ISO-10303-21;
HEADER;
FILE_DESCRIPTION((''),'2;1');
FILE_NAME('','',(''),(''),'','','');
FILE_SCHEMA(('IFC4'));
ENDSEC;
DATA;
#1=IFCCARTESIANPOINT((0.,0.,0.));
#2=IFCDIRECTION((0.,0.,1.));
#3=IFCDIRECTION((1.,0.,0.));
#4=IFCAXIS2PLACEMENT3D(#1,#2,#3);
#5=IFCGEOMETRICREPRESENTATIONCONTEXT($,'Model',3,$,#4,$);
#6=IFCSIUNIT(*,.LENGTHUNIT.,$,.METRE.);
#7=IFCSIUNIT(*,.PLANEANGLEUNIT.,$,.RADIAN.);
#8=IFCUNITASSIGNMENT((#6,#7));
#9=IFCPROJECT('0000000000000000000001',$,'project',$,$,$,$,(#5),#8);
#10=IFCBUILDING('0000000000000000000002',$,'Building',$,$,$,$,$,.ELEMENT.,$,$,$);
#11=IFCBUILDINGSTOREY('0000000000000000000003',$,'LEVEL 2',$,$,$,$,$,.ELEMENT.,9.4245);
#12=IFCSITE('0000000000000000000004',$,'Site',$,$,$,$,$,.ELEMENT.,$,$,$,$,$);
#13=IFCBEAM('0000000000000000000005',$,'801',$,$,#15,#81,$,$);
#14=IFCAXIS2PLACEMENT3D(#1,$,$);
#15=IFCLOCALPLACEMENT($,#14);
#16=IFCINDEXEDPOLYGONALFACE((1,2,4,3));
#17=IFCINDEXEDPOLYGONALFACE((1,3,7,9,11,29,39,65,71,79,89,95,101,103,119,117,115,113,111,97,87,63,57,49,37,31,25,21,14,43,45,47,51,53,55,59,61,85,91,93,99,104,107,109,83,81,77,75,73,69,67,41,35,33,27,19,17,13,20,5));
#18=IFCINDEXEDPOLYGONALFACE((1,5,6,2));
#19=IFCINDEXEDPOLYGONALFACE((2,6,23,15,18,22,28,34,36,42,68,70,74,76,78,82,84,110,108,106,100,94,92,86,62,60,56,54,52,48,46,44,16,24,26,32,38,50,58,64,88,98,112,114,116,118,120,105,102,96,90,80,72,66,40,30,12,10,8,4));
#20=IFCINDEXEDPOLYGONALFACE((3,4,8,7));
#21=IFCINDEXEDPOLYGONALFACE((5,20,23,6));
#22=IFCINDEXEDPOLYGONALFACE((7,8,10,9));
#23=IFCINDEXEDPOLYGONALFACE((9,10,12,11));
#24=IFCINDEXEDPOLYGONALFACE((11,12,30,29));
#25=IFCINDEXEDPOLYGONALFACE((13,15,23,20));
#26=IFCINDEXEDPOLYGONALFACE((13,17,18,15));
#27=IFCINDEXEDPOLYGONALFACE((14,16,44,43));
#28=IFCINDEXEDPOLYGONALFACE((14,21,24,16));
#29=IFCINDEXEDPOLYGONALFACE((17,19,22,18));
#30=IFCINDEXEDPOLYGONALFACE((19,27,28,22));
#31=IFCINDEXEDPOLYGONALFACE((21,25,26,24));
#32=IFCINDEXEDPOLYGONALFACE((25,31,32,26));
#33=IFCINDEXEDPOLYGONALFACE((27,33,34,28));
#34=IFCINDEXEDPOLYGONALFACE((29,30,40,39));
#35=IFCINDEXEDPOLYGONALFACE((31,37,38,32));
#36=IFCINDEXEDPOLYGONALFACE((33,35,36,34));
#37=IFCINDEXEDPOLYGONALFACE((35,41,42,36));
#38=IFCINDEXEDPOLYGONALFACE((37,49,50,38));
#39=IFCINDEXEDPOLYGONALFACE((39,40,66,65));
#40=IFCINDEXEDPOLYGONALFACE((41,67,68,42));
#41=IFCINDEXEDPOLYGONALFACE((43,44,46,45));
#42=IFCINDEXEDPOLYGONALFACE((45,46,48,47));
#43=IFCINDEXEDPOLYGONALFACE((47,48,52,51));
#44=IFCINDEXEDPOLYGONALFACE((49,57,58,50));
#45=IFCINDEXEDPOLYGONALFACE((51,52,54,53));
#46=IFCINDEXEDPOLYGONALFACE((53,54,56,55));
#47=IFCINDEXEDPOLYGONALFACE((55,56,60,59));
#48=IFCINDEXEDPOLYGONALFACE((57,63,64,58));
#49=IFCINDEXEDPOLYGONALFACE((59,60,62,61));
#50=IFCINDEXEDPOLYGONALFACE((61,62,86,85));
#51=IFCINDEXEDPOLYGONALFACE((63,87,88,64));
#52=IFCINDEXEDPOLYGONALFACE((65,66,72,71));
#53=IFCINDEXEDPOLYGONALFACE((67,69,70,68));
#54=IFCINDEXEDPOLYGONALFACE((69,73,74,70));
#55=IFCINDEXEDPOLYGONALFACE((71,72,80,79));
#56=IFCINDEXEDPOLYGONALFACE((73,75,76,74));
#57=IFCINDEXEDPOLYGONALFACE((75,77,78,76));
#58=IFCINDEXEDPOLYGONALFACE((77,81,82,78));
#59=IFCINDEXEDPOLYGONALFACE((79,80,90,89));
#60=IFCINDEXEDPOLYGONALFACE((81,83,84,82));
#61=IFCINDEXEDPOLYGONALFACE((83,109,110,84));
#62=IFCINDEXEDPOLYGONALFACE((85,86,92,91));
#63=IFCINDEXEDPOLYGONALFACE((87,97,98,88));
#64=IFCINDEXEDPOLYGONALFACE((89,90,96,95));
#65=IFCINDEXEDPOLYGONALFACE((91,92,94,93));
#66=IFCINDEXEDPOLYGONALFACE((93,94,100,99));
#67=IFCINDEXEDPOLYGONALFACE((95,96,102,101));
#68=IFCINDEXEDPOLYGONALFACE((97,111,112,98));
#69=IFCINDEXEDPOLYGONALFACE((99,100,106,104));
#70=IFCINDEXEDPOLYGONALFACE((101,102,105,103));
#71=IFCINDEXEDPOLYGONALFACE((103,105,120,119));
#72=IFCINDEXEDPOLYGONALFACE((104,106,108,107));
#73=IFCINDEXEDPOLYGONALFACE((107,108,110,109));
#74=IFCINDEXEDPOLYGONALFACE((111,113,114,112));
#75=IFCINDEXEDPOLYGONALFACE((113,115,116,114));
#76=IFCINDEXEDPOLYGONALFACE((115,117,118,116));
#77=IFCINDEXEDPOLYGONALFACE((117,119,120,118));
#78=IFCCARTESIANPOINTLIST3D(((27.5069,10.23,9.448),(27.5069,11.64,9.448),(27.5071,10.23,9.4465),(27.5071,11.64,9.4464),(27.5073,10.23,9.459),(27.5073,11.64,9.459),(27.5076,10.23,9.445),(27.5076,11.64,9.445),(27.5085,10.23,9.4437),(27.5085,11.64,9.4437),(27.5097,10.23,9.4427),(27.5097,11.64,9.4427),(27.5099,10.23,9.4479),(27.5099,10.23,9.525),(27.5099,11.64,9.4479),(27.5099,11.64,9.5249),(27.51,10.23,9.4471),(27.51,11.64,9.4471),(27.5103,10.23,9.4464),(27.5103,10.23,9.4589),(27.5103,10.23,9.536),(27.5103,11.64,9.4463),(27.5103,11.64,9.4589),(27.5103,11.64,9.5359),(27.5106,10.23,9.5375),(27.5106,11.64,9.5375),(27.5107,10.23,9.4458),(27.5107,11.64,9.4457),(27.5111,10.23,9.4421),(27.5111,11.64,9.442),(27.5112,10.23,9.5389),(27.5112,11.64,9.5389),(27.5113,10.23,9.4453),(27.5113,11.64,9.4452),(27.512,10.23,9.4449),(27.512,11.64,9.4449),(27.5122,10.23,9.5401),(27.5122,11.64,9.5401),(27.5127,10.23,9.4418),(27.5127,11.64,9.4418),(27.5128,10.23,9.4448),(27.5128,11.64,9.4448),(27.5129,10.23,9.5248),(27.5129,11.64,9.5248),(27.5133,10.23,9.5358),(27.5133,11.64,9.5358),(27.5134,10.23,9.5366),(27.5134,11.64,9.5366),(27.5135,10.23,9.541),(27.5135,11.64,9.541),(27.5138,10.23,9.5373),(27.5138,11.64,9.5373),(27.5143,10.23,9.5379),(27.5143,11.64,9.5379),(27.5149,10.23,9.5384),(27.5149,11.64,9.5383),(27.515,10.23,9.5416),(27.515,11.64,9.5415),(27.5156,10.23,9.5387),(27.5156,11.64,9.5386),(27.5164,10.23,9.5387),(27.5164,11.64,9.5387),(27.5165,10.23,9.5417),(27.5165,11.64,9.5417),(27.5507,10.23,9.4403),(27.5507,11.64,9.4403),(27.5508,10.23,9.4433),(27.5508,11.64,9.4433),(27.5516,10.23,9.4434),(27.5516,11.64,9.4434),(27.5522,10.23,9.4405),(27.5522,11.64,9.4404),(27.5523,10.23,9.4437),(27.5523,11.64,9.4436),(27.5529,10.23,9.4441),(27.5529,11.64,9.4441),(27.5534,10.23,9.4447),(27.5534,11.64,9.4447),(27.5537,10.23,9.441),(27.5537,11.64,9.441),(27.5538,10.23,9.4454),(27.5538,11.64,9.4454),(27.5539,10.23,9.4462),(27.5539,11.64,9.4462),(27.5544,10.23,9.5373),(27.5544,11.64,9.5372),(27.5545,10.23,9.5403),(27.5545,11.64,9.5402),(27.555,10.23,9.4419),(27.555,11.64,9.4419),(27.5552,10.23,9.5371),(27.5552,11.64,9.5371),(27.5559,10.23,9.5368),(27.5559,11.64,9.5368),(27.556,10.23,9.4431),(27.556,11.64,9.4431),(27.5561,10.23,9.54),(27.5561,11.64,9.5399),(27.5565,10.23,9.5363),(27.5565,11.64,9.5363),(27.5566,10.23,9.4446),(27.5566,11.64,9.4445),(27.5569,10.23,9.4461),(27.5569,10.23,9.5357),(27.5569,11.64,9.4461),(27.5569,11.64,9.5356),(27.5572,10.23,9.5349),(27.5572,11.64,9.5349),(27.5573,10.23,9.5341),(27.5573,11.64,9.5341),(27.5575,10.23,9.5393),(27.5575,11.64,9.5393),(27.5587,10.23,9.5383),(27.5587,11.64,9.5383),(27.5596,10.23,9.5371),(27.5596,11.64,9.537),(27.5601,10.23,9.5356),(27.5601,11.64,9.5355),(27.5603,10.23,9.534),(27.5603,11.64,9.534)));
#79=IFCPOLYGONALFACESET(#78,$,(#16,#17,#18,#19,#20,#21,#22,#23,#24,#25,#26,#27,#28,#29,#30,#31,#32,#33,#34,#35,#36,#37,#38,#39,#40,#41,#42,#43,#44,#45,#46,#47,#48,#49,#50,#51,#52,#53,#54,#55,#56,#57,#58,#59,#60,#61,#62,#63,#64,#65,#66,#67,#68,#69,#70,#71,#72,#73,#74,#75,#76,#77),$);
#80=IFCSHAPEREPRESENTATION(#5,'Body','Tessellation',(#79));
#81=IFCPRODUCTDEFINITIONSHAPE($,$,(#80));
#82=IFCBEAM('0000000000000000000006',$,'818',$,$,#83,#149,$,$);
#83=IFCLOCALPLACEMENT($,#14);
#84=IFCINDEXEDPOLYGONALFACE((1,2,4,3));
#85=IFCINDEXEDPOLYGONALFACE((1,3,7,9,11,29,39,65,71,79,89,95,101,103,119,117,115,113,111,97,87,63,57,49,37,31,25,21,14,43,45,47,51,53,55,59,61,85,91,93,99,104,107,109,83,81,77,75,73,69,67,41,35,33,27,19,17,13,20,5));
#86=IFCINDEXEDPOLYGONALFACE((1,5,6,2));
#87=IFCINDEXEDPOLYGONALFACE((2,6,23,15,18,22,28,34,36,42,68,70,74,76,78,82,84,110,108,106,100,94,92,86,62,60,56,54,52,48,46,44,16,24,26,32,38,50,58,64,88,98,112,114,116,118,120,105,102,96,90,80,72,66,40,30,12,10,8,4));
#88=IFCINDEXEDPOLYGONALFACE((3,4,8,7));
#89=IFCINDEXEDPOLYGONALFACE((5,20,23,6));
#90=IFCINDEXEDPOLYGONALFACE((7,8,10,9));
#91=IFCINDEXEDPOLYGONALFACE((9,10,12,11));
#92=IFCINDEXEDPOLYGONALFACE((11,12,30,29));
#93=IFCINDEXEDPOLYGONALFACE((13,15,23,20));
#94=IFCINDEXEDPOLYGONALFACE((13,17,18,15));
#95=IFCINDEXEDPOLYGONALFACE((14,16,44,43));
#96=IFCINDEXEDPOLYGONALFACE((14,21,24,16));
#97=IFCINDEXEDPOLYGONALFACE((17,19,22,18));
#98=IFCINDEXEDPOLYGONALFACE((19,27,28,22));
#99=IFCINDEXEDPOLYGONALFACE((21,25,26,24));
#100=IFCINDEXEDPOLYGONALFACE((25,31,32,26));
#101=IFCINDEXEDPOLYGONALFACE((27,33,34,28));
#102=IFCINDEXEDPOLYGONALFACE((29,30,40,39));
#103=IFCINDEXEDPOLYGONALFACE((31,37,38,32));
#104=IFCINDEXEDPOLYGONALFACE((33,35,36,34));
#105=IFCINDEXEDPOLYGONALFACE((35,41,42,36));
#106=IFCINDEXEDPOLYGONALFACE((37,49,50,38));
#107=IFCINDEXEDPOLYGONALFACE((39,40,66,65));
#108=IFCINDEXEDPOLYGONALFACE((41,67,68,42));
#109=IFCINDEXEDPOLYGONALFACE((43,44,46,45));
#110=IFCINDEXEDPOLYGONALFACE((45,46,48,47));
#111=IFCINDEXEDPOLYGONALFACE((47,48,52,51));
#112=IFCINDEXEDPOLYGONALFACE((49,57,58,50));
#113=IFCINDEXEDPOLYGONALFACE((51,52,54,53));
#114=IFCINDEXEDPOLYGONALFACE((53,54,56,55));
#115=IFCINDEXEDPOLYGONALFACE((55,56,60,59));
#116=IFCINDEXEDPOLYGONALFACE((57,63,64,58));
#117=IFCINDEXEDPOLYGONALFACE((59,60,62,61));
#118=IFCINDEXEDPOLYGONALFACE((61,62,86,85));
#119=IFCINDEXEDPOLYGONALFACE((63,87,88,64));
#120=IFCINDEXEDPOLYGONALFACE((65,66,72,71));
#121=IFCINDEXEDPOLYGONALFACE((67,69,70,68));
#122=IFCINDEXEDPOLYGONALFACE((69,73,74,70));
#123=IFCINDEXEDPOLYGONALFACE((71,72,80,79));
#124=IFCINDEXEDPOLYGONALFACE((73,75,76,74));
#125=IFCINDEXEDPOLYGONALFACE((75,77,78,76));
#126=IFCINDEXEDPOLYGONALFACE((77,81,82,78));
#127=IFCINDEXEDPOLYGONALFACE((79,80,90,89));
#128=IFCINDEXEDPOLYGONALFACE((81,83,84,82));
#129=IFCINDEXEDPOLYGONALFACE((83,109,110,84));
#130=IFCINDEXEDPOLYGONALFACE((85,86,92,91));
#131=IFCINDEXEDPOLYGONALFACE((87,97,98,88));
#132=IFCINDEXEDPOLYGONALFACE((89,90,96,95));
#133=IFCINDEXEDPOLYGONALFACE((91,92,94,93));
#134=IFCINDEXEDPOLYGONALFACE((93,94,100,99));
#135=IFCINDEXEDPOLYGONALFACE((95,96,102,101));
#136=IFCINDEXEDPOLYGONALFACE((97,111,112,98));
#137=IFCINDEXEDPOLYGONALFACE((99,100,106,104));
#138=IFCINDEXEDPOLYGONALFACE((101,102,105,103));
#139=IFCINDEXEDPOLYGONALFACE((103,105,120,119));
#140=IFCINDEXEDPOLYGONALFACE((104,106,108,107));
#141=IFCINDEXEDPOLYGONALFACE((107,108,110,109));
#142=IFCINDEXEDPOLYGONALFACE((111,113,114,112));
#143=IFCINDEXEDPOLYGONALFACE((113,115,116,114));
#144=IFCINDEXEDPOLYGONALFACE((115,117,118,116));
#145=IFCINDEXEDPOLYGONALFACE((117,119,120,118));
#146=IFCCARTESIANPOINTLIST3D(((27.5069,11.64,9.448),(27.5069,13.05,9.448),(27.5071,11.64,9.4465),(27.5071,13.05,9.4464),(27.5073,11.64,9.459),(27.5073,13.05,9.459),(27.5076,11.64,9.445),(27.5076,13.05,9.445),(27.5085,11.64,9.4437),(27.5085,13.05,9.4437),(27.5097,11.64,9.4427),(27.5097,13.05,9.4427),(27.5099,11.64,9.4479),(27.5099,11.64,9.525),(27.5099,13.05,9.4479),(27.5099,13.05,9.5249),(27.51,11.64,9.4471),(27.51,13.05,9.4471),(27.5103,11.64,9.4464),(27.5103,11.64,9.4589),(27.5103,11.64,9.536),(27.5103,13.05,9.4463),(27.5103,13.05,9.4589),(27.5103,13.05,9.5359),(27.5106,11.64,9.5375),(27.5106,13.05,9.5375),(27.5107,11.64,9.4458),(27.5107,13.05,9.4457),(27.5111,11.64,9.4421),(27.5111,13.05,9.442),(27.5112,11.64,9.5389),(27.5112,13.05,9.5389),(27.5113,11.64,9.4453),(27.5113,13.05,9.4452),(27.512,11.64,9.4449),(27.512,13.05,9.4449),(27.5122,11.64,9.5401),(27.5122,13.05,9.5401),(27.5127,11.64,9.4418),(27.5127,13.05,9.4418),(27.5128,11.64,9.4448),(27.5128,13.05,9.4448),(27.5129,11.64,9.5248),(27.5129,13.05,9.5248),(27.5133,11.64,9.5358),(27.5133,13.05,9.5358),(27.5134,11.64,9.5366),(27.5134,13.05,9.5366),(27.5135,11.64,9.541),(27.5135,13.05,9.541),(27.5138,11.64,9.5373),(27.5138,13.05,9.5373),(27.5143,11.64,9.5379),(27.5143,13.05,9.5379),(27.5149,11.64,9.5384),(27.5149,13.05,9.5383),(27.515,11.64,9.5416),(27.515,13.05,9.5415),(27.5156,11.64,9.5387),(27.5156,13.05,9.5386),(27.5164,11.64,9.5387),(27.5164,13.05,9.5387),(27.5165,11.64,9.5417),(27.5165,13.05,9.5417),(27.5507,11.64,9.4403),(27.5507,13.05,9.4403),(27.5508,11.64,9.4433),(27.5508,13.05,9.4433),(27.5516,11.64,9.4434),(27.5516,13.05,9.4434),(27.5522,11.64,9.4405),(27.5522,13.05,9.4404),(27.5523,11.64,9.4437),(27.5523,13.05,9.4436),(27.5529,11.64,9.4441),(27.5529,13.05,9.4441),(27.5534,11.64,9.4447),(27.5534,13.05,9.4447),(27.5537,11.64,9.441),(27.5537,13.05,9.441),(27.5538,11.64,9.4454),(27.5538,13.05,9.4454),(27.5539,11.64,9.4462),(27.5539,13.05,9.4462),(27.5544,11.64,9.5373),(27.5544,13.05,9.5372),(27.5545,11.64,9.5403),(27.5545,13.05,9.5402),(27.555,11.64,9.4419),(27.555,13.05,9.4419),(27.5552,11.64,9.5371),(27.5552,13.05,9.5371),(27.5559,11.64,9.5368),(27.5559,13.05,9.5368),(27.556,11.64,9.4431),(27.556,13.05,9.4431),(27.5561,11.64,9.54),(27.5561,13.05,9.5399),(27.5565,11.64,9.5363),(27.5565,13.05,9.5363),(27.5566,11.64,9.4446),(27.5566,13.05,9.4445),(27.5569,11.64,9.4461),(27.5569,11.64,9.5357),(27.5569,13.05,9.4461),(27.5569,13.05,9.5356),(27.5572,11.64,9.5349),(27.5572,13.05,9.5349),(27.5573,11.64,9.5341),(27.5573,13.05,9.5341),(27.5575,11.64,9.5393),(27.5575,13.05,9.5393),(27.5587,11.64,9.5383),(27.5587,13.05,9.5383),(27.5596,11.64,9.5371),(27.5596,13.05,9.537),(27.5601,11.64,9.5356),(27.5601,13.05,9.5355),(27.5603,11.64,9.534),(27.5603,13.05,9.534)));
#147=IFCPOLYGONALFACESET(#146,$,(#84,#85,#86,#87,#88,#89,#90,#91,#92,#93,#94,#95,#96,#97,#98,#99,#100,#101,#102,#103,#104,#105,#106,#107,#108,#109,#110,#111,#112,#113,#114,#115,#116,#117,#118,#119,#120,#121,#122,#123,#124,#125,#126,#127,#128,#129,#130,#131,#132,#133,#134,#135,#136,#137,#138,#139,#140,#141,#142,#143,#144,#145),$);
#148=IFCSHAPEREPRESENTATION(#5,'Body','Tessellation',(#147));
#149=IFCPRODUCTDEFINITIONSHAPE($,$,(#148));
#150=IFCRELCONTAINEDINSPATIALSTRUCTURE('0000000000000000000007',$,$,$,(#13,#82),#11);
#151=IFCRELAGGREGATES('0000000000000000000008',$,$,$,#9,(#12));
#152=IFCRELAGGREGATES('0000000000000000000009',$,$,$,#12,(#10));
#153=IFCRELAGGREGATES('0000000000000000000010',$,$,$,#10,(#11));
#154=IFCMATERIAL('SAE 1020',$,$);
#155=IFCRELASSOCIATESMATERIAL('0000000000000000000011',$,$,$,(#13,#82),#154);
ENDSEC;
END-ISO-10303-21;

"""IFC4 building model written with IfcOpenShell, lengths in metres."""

from ifc_helpers import new_model, si_unit, frame, origin_with_axes, origin_2d_with_axis, place, context, project, spatial, c_section, extrude, material, material_profile, profile_set, profile_usage, element, save


model = new_model("IFC4")

# Units and contexts
model_context = context("Model", 3, world=origin_with_axes())
ifc_project = project(units=[si_unit("LENGTHUNIT", "METRE"), si_unit("PLANEANGLEUNIT", "RADIAN")], contexts=[model_context])

# Site, building, storey
site = spatial("IfcSite", under=ifc_project, Name="Site", CompositionType="ELEMENT")
building = spatial("IfcBuilding", under=site, Name="Building", CompositionType="ELEMENT")
storey = spatial("IfcBuildingStorey", under=building, Name="LEVEL 2", CompositionType="ELEMENT", Elevation=9.4245)

# Beams
ifc_material = material(Name="SAE 1020")
ifc_material_profile_1 = material_profile(ifc_material, c_section(Depth=0.1, Width=0.05, WallThickness=0.003, Girth=0.017, InternalFilletRadius=0.003, at=origin_2d_with_axis()))
ifc_profile_set_1 = profile_set([ifc_material_profile_1])
ifc_profile_usage_1 = profile_usage(ifc_profile_set_1, cardinal=10)
beam_1_placement = place(None, frame((27.5336, 10.23, 9.491), z_axis=(0.0, 1.0, -0.00003), x_axis=(-0.999256, 0.000001, 0.038562)))
element("IfcBeam", 1, at=beam_1_placement, inside=storey, material=ifc_profile_usage_1, Name="801", context=model_context, shape_type="SweptSolid", body=[
    extrude(c_section(Depth=0.1, Width=0.05, WallThickness=0.003, Girth=0.017, InternalFilletRadius=0.003, at=origin_2d_with_axis()), origin_with_axes(), (0.0, 0.0, 1.0), 1.41),
])
ifc_material_profile_2 = material_profile(ifc_material, c_section(Depth=0.1, Width=0.05, WallThickness=0.003, Girth=0.017, InternalFilletRadius=0.003, at=origin_2d_with_axis()))
ifc_profile_set_2 = profile_set([ifc_material_profile_2])
ifc_profile_usage_2 = profile_usage(ifc_profile_set_2, cardinal=10)
beam_2_placement = place(None, frame((27.5336, 11.64, 9.491), z_axis=(0.0, 1.0, -0.00003), x_axis=(-0.999256, 0.000001, 0.038562)))
element("IfcBeam", 2, at=beam_2_placement, inside=storey, material=ifc_profile_usage_2, Name="818", context=model_context, shape_type="SweptSolid", body=[
    extrude(c_section(Depth=0.1, Width=0.05, WallThickness=0.003, Girth=0.017, InternalFilletRadius=0.003, at=origin_2d_with_axis()), origin_with_axes(), (0.0, 0.0, 1.0), 1.41),
])

save(model, "model.ifc")
